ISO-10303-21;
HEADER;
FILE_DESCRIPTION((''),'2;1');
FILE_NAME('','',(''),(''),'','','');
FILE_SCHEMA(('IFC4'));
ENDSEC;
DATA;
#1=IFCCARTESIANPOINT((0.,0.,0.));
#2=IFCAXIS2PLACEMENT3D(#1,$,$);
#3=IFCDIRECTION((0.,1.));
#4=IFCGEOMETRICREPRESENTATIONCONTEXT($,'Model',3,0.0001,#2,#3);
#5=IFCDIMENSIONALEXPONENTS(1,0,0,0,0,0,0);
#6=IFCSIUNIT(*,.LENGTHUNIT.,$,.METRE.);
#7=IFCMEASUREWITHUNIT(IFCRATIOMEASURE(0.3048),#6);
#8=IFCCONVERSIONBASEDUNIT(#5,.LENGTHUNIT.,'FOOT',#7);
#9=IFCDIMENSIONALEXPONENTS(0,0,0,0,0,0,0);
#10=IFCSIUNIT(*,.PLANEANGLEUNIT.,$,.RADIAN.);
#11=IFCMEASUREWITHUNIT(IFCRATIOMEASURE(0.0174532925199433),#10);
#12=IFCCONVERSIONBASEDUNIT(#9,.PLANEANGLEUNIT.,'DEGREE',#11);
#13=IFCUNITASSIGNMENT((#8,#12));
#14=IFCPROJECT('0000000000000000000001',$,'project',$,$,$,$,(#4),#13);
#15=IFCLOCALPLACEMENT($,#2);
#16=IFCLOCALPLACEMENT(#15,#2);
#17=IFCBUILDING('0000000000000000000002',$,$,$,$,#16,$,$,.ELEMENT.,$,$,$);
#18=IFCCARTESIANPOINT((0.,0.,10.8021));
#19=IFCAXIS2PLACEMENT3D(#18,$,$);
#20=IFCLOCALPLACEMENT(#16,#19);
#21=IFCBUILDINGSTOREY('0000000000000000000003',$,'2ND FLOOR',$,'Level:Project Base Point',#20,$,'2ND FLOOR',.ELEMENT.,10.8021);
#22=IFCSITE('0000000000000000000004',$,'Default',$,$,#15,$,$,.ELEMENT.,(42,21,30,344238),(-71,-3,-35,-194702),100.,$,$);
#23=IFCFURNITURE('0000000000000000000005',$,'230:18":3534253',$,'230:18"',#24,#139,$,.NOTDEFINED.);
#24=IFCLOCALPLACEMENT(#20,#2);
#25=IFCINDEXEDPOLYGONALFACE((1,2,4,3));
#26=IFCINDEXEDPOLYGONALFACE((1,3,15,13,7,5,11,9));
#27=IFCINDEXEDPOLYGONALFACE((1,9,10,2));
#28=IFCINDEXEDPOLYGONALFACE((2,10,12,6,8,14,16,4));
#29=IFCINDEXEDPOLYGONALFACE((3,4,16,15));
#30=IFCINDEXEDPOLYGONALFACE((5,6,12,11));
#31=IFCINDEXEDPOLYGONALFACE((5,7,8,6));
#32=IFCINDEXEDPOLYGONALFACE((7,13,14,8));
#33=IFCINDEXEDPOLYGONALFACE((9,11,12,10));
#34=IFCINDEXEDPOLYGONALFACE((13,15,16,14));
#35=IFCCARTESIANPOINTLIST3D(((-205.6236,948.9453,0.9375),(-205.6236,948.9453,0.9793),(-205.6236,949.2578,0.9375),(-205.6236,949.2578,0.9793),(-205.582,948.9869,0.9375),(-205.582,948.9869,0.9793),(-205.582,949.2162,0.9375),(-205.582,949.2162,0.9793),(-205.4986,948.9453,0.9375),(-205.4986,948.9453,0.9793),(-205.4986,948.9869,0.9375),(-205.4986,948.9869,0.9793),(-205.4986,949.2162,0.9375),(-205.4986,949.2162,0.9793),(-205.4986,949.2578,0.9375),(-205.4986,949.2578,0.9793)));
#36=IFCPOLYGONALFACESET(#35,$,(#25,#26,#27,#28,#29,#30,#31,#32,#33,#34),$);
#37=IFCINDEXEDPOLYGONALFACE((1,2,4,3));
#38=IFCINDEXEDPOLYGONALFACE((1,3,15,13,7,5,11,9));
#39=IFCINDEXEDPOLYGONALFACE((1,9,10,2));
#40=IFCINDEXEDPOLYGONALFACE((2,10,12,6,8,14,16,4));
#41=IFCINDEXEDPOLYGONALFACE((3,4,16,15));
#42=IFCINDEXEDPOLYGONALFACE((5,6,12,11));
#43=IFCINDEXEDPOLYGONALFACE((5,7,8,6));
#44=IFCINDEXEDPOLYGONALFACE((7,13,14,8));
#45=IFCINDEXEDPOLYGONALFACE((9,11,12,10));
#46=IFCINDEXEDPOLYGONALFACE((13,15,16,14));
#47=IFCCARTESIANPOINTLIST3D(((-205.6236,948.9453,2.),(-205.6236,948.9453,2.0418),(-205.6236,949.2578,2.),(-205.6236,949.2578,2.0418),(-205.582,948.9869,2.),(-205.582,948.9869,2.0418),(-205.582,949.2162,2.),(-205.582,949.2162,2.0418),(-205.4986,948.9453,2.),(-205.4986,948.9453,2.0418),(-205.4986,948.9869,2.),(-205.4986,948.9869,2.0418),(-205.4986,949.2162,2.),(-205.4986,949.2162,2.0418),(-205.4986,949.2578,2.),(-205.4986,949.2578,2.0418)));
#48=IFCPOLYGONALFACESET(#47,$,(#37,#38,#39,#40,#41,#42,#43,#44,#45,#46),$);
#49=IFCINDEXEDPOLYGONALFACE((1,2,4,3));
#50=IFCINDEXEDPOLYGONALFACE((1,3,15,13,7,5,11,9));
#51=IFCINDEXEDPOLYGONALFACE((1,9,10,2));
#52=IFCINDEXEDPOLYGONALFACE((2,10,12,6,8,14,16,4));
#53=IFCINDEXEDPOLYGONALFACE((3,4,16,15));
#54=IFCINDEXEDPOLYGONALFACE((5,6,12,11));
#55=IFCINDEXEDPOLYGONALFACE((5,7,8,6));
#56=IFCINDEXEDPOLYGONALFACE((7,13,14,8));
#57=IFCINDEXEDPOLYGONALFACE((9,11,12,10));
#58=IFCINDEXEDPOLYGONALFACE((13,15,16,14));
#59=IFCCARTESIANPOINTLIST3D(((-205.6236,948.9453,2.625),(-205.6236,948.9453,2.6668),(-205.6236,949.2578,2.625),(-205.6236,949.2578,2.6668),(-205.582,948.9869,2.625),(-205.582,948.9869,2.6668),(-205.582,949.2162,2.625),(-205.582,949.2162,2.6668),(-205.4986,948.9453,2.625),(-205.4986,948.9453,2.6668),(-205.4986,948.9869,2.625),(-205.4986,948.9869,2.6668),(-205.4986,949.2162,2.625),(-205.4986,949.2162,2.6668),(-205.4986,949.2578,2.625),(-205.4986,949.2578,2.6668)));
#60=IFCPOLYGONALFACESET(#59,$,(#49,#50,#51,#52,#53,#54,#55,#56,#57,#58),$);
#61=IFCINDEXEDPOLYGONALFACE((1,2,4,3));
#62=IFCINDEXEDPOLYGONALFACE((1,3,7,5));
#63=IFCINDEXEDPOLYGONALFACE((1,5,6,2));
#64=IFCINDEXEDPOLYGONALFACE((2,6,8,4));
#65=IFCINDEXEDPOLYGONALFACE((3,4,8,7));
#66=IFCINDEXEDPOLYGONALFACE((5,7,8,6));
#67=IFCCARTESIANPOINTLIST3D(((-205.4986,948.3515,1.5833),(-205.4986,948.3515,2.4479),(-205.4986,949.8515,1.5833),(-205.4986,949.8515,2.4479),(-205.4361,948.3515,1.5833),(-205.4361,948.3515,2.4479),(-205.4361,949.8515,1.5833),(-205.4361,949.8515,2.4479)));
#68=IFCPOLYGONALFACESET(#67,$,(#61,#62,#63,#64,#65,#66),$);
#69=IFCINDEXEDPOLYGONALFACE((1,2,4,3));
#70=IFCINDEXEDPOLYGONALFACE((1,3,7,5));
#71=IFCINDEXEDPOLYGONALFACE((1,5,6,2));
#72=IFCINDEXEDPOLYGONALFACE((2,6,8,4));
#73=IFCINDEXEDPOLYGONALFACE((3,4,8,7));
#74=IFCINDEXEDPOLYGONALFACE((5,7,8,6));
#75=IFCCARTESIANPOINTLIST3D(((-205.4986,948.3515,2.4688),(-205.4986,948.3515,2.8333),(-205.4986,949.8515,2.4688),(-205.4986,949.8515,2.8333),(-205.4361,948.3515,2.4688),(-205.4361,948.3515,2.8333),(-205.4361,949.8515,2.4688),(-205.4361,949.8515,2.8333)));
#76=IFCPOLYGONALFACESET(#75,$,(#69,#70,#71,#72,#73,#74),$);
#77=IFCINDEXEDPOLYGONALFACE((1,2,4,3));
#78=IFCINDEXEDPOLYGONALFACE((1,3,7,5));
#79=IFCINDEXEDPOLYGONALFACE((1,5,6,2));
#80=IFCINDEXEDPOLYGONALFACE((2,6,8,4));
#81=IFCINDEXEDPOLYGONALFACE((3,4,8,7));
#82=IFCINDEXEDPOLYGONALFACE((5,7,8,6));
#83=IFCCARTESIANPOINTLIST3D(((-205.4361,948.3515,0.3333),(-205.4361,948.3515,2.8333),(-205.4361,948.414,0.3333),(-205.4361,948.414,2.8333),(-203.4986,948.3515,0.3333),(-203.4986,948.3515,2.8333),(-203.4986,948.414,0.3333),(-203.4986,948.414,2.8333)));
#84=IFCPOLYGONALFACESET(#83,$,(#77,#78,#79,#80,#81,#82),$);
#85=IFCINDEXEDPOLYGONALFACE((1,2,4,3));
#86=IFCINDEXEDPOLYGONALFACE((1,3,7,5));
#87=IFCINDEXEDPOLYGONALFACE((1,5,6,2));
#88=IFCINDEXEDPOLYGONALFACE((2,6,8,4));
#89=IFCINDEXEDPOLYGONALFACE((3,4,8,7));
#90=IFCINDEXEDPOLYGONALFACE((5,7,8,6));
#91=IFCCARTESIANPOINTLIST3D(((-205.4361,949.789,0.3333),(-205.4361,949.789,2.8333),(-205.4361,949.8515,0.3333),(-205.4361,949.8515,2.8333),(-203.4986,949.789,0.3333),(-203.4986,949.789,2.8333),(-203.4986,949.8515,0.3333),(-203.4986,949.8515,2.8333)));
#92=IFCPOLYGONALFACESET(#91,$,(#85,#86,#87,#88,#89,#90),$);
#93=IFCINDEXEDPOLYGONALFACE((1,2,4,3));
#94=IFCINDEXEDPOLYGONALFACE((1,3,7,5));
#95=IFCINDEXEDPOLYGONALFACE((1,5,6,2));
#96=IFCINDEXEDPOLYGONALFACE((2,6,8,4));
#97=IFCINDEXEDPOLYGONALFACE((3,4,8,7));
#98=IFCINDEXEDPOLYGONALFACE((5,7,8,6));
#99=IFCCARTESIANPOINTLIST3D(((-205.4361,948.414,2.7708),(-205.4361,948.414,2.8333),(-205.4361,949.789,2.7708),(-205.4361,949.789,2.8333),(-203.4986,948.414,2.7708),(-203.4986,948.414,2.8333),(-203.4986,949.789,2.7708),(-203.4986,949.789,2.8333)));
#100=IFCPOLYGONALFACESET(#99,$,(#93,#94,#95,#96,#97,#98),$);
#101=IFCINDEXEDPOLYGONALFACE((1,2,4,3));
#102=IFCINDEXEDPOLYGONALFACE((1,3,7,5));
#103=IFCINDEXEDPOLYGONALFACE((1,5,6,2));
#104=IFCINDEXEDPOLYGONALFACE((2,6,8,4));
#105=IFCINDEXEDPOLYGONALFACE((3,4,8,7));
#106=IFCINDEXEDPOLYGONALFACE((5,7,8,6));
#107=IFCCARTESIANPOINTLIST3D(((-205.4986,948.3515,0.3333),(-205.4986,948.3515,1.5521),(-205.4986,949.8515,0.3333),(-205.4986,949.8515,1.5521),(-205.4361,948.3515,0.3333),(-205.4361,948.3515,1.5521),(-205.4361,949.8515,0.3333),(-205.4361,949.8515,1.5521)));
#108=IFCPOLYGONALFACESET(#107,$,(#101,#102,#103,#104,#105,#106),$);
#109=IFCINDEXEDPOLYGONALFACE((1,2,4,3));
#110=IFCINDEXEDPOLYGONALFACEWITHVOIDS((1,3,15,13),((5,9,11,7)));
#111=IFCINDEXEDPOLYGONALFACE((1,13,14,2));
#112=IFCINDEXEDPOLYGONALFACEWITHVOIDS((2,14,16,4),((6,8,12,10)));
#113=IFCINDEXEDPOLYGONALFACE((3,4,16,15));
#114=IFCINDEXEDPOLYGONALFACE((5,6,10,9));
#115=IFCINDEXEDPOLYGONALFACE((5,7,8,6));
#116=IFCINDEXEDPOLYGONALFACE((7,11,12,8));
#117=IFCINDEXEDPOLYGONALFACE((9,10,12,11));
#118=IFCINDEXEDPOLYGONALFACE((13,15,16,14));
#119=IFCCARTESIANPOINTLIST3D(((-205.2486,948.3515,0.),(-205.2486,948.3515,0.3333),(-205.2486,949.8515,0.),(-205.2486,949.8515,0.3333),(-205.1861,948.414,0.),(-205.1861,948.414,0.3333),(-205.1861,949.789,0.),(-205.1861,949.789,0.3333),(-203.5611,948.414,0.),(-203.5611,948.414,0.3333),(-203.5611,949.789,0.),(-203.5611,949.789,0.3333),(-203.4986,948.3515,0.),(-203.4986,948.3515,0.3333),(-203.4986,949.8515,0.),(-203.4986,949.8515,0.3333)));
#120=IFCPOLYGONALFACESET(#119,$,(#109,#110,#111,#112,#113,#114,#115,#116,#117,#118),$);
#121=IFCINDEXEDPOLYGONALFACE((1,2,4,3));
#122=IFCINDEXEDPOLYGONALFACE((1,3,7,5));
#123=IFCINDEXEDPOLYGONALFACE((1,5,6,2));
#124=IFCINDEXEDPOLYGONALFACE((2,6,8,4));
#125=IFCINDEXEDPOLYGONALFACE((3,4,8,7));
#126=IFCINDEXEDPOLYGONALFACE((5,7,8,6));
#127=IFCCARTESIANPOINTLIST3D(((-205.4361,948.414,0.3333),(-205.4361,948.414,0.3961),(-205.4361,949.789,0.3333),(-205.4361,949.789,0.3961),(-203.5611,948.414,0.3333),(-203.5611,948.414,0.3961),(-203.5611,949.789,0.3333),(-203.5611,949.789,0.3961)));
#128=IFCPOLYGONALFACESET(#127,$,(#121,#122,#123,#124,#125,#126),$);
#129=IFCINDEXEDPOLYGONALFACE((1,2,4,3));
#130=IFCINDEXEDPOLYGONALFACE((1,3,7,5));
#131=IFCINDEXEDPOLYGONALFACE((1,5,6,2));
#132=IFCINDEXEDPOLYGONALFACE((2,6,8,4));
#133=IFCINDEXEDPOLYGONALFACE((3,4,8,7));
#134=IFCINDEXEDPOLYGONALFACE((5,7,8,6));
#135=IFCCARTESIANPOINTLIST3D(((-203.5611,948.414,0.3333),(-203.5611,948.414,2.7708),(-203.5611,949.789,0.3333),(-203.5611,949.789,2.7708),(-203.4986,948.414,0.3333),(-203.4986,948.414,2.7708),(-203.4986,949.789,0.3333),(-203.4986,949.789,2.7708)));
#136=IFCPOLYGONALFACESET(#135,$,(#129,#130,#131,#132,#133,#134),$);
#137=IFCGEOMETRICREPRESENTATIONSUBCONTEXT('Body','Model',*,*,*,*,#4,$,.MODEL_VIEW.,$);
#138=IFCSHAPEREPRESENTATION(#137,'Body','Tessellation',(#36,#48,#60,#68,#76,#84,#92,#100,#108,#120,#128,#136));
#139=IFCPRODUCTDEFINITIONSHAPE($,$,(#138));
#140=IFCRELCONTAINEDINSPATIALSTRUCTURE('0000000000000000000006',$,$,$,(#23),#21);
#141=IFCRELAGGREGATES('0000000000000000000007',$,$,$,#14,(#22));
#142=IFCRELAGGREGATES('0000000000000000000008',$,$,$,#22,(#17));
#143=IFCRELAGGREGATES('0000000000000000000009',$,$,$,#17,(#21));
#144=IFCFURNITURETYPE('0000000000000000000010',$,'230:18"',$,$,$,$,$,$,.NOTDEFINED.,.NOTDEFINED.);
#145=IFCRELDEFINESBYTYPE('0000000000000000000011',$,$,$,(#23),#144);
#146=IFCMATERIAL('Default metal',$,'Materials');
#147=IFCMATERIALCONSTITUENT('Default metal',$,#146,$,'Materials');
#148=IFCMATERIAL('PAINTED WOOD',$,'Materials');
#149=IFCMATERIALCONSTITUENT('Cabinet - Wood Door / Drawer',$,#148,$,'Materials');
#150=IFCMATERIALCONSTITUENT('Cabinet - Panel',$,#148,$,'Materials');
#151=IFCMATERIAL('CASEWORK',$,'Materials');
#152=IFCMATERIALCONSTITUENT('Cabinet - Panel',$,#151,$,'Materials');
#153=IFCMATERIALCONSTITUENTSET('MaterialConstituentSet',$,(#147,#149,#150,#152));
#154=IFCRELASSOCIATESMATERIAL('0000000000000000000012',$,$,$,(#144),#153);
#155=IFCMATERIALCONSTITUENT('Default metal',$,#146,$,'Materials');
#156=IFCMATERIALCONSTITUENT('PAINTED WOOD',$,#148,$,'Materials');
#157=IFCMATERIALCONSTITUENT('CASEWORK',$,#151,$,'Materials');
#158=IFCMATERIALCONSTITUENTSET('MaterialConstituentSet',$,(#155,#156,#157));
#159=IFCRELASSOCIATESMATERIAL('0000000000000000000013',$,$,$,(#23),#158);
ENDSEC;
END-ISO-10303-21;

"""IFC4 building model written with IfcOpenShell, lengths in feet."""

from ifc_helpers import new_model, entity, si_unit, converted_unit, direction, frame, frame_2d, origin, origin_2d_with_axis, place, context, subcontext, project, spatial, polyline, rectangle, outline, extrude, source, transform, mapped, material, constituent, constituent_set, type_object, type_shapes, element, save


model = new_model("IFC4")

# Units and contexts
model_context = context("Model", 3, precision=0.0001, world=origin(), true_north=direction((0.0, 1.0)))
body_context = subcontext(model_context, "Body", "Model", "MODEL_VIEW")
ifc_project = project(units=[converted_unit("LENGTHUNIT", "FOOT", entity("IfcRatioMeasure", 0.3048), si_unit("LENGTHUNIT", "METRE"), dimensions=[1, 0, 0, 0, 0, 0, 0]), converted_unit("PLANEANGLEUNIT", "DEGREE", entity("IfcRatioMeasure", 0.0174532925199433), si_unit("PLANEANGLEUNIT", "RADIAN"), dimensions=[0, 0, 0, 0, 0, 0, 0])], contexts=[model_context])

# Site, building, storey
site_placement = place(None, origin())
site = spatial("IfcSite", under=ifc_project, at=site_placement, Name="Default", CompositionType="ELEMENT", RefLatitude=(42, 21, 30, 344238), RefLongitude=(-71, -3, -35, -194702), RefElevation=100.0)
building_placement = place(site_placement, origin())
building = spatial("IfcBuilding", under=site, at=building_placement, CompositionType="ELEMENT")
storey_placement = place(building_placement, frame((0.0, 0.0, 10.8021)))
storey = spatial("IfcBuildingStorey", under=building, at=storey_placement, Name="2ND FLOOR", ObjectType="Level:Project Base Point", LongName="2ND FLOOR", CompositionType="ELEMENT", Elevation=10.8021)

# Furniture
ifc_material_1 = material(Name="CASEWORK", Category="Materials")
ifc_material_2 = material(Name="PAINTED WOOD", Category="Materials")
ifc_material_3 = material(Name="Default metal", Category="Materials")
ifc_constituent_1 = constituent(ifc_material_3, Name="Default metal", Category="Materials")
ifc_constituent_2 = constituent(ifc_material_2, Name="PAINTED WOOD", Category="Materials")
ifc_constituent_3 = constituent(ifc_material_1, Name="CASEWORK", Category="Materials")
ifc_constituent_set_1 = constituent_set(constituents=[ifc_constituent_1, ifc_constituent_2, ifc_constituent_3], Name="MaterialConstituentSet")
ifc_constituent_4 = constituent(ifc_material_3, Name="Default metal", Category="Materials")
ifc_constituent_5 = constituent(ifc_material_2, Name="Cabinet - Wood Door / Drawer", Category="Materials")
ifc_constituent_6 = constituent(ifc_material_2, Name="Cabinet - Panel", Category="Materials")
ifc_constituent_7 = constituent(ifc_material_1, Name="Cabinet - Panel", Category="Materials")
ifc_constituent_set_2 = constituent_set(constituents=[ifc_constituent_4, ifc_constituent_5, ifc_constituent_6, ifc_constituent_7], Name="MaterialConstituentSet")
furniture_type_1 = type_object("IfcFurnitureType", Name="230:18\"", AssemblyPlace="NOTDEFINED", PredefinedType="NOTDEFINED", material=ifc_constituent_set_2)
shared_shape_1 = source(origin(), body_context, "Body", "SweptSolid", [
    extrude(outline(polyline([(-0.1562, -0.0521), (-0.1146, -0.0521), (-0.1146, 0.0313), (0.1146, 0.0313), (0.1146, -0.0521), (0.1562, -0.0521), (0.1562, 0.0729), (-0.1562, 0.0729), (-0.1562, -0.0521)])), frame((0.0615, 2.0521, 0.9375)), (0.0, 0.0, 1.0), 0.0418),
    extrude(outline(polyline([(-0.1562, -0.0521), (-0.1146, -0.0521), (-0.1146, 0.0313), (0.1146, 0.0313), (0.1146, -0.0521), (0.1562, -0.0521), (0.1562, 0.0729), (-0.1562, 0.0729), (-0.1562, -0.0521)])), frame((0.0615, 2.0521, 2.0)), (0.0, 0.0, 1.0), 0.0418),
    extrude(outline(polyline([(-0.1562, -0.0521), (-0.1146, -0.0521), (-0.1146, 0.0313), (0.1146, 0.0313), (0.1146, -0.0521), (0.1562, -0.0521), (0.1562, 0.0729), (-0.1562, 0.0729), (-0.1562, -0.0521)])), frame((0.0615, 2.0521, 2.625)), (0.0, 0.0, 1.0), 0.0418),
    extrude(rectangle(XDim=1.5, YDim=0.0625, at=frame_2d((0.0, 0.0), x_axis=(1.0, 0.0))), frame((0.0615, 1.9688, 1.5833), z_axis=(0.0, 0.0, 1.0), x_axis=(-1.0, 0.0, 0.0)), (0.0, 0.0, 1.0), 0.8646),
    extrude(rectangle(XDim=1.5, YDim=0.0625, at=frame_2d((0.0, 0.0), x_axis=(1.0, 0.0))), frame((0.0615, 1.9688, 2.4688), z_axis=(0.0, 0.0, 1.0), x_axis=(-1.0, 0.0, 0.0)), (0.0, 0.0, 1.0), 0.3646),
    extrude(rectangle(XDim=1.9375, YDim=0.0625, at=frame_2d((0.0, 0.0), x_axis=(1.0, 0.0))), frame((-0.6573, 0.9687, 0.3333), z_axis=(0.0, 0.0, 1.0), x_axis=(0.0, -1.0, 0.0)), (0.0, 0.0, 1.0), 2.5),
    extrude(rectangle(XDim=1.9375, YDim=0.0625, at=frame_2d((0.0, 0.0), x_axis=(1.0, 0.0))), frame((0.7802, 0.9687, 0.3333), z_axis=(0.0, 0.0, 1.0), x_axis=(0.0, -1.0, 0.0)), (0.0, 0.0, 1.0), 2.5),
    extrude(rectangle(XDim=1.9375, YDim=1.375, at=origin_2d_with_axis()), frame((0.0615, 0.9687, 2.7708), z_axis=(0.0, 0.0, 1.0), x_axis=(0.0, 1.0, 0.0)), (0.0, 0.0, 1.0), 0.0625),
    extrude(rectangle(XDim=1.5, YDim=0.0625, at=frame_2d((0.0, 0.0), x_axis=(1.0, 0.0))), frame((0.0615, 1.9688, 0.3333), z_axis=(0.0, 0.0, 1.0), x_axis=(-1.0, 0.0, 0.0)), (0.0, 0.0, 1.0), 1.2187),
    extrude(outline(polyline([(-0.875, -0.75), (0.875, -0.75), (0.875, 0.75), (-0.875, 0.75), (-0.875, -0.75)]), holes=[polyline([(-0.8125, -0.6875), (-0.8125, 0.6875), (0.8125, 0.6875), (0.8125, -0.6875), (-0.8125, -0.6875)])]), frame((0.0615, 0.875, 0.0), z_axis=(0.0, 0.0, 1.0), x_axis=(0.0, -1.0, 0.0)), (0.0, 0.0, 1.0), 0.3333),
    extrude(rectangle(XDim=1.875, YDim=1.375, at=origin_2d_with_axis()), frame((0.0615, 1.0, 0.3333), z_axis=(0.0, 0.0, 1.0), x_axis=(0.0, 1.0, 0.0)), (0.0, 0.0, 1.0), 0.0627),
    extrude(rectangle(XDim=1.375, YDim=0.0625, at=origin_2d_with_axis()), frame((0.0615, 0.0312, 0.3333), z_axis=(0.0, 0.0, 1.0), x_axis=(-1.0, 0.0, 0.0)), (0.0, 0.0, 1.0), 2.4375),
])
type_shapes(furniture_type_1, [shared_shape_1])
furniture_1_placement = place(storey_placement, frame((-203.4986, 949.04, 0.0), z_axis=(0.0, 0.0, 1.0), x_axis=(0.0, 1.0, 0.0)))
element("IfcFurniture", 1, at=furniture_1_placement, inside=storey, type_object=furniture_type_1, material=ifc_constituent_set_1, Name="230:18\":3534253", ObjectType="230:18\"", PredefinedType="NOTDEFINED", context=body_context, shape_type="MappedRepresentation", body=[
    mapped(shared_shape_1, transform((0.0, 0.0, 0.0), scale=1.0)),
])

save(model, "model.ifc")
